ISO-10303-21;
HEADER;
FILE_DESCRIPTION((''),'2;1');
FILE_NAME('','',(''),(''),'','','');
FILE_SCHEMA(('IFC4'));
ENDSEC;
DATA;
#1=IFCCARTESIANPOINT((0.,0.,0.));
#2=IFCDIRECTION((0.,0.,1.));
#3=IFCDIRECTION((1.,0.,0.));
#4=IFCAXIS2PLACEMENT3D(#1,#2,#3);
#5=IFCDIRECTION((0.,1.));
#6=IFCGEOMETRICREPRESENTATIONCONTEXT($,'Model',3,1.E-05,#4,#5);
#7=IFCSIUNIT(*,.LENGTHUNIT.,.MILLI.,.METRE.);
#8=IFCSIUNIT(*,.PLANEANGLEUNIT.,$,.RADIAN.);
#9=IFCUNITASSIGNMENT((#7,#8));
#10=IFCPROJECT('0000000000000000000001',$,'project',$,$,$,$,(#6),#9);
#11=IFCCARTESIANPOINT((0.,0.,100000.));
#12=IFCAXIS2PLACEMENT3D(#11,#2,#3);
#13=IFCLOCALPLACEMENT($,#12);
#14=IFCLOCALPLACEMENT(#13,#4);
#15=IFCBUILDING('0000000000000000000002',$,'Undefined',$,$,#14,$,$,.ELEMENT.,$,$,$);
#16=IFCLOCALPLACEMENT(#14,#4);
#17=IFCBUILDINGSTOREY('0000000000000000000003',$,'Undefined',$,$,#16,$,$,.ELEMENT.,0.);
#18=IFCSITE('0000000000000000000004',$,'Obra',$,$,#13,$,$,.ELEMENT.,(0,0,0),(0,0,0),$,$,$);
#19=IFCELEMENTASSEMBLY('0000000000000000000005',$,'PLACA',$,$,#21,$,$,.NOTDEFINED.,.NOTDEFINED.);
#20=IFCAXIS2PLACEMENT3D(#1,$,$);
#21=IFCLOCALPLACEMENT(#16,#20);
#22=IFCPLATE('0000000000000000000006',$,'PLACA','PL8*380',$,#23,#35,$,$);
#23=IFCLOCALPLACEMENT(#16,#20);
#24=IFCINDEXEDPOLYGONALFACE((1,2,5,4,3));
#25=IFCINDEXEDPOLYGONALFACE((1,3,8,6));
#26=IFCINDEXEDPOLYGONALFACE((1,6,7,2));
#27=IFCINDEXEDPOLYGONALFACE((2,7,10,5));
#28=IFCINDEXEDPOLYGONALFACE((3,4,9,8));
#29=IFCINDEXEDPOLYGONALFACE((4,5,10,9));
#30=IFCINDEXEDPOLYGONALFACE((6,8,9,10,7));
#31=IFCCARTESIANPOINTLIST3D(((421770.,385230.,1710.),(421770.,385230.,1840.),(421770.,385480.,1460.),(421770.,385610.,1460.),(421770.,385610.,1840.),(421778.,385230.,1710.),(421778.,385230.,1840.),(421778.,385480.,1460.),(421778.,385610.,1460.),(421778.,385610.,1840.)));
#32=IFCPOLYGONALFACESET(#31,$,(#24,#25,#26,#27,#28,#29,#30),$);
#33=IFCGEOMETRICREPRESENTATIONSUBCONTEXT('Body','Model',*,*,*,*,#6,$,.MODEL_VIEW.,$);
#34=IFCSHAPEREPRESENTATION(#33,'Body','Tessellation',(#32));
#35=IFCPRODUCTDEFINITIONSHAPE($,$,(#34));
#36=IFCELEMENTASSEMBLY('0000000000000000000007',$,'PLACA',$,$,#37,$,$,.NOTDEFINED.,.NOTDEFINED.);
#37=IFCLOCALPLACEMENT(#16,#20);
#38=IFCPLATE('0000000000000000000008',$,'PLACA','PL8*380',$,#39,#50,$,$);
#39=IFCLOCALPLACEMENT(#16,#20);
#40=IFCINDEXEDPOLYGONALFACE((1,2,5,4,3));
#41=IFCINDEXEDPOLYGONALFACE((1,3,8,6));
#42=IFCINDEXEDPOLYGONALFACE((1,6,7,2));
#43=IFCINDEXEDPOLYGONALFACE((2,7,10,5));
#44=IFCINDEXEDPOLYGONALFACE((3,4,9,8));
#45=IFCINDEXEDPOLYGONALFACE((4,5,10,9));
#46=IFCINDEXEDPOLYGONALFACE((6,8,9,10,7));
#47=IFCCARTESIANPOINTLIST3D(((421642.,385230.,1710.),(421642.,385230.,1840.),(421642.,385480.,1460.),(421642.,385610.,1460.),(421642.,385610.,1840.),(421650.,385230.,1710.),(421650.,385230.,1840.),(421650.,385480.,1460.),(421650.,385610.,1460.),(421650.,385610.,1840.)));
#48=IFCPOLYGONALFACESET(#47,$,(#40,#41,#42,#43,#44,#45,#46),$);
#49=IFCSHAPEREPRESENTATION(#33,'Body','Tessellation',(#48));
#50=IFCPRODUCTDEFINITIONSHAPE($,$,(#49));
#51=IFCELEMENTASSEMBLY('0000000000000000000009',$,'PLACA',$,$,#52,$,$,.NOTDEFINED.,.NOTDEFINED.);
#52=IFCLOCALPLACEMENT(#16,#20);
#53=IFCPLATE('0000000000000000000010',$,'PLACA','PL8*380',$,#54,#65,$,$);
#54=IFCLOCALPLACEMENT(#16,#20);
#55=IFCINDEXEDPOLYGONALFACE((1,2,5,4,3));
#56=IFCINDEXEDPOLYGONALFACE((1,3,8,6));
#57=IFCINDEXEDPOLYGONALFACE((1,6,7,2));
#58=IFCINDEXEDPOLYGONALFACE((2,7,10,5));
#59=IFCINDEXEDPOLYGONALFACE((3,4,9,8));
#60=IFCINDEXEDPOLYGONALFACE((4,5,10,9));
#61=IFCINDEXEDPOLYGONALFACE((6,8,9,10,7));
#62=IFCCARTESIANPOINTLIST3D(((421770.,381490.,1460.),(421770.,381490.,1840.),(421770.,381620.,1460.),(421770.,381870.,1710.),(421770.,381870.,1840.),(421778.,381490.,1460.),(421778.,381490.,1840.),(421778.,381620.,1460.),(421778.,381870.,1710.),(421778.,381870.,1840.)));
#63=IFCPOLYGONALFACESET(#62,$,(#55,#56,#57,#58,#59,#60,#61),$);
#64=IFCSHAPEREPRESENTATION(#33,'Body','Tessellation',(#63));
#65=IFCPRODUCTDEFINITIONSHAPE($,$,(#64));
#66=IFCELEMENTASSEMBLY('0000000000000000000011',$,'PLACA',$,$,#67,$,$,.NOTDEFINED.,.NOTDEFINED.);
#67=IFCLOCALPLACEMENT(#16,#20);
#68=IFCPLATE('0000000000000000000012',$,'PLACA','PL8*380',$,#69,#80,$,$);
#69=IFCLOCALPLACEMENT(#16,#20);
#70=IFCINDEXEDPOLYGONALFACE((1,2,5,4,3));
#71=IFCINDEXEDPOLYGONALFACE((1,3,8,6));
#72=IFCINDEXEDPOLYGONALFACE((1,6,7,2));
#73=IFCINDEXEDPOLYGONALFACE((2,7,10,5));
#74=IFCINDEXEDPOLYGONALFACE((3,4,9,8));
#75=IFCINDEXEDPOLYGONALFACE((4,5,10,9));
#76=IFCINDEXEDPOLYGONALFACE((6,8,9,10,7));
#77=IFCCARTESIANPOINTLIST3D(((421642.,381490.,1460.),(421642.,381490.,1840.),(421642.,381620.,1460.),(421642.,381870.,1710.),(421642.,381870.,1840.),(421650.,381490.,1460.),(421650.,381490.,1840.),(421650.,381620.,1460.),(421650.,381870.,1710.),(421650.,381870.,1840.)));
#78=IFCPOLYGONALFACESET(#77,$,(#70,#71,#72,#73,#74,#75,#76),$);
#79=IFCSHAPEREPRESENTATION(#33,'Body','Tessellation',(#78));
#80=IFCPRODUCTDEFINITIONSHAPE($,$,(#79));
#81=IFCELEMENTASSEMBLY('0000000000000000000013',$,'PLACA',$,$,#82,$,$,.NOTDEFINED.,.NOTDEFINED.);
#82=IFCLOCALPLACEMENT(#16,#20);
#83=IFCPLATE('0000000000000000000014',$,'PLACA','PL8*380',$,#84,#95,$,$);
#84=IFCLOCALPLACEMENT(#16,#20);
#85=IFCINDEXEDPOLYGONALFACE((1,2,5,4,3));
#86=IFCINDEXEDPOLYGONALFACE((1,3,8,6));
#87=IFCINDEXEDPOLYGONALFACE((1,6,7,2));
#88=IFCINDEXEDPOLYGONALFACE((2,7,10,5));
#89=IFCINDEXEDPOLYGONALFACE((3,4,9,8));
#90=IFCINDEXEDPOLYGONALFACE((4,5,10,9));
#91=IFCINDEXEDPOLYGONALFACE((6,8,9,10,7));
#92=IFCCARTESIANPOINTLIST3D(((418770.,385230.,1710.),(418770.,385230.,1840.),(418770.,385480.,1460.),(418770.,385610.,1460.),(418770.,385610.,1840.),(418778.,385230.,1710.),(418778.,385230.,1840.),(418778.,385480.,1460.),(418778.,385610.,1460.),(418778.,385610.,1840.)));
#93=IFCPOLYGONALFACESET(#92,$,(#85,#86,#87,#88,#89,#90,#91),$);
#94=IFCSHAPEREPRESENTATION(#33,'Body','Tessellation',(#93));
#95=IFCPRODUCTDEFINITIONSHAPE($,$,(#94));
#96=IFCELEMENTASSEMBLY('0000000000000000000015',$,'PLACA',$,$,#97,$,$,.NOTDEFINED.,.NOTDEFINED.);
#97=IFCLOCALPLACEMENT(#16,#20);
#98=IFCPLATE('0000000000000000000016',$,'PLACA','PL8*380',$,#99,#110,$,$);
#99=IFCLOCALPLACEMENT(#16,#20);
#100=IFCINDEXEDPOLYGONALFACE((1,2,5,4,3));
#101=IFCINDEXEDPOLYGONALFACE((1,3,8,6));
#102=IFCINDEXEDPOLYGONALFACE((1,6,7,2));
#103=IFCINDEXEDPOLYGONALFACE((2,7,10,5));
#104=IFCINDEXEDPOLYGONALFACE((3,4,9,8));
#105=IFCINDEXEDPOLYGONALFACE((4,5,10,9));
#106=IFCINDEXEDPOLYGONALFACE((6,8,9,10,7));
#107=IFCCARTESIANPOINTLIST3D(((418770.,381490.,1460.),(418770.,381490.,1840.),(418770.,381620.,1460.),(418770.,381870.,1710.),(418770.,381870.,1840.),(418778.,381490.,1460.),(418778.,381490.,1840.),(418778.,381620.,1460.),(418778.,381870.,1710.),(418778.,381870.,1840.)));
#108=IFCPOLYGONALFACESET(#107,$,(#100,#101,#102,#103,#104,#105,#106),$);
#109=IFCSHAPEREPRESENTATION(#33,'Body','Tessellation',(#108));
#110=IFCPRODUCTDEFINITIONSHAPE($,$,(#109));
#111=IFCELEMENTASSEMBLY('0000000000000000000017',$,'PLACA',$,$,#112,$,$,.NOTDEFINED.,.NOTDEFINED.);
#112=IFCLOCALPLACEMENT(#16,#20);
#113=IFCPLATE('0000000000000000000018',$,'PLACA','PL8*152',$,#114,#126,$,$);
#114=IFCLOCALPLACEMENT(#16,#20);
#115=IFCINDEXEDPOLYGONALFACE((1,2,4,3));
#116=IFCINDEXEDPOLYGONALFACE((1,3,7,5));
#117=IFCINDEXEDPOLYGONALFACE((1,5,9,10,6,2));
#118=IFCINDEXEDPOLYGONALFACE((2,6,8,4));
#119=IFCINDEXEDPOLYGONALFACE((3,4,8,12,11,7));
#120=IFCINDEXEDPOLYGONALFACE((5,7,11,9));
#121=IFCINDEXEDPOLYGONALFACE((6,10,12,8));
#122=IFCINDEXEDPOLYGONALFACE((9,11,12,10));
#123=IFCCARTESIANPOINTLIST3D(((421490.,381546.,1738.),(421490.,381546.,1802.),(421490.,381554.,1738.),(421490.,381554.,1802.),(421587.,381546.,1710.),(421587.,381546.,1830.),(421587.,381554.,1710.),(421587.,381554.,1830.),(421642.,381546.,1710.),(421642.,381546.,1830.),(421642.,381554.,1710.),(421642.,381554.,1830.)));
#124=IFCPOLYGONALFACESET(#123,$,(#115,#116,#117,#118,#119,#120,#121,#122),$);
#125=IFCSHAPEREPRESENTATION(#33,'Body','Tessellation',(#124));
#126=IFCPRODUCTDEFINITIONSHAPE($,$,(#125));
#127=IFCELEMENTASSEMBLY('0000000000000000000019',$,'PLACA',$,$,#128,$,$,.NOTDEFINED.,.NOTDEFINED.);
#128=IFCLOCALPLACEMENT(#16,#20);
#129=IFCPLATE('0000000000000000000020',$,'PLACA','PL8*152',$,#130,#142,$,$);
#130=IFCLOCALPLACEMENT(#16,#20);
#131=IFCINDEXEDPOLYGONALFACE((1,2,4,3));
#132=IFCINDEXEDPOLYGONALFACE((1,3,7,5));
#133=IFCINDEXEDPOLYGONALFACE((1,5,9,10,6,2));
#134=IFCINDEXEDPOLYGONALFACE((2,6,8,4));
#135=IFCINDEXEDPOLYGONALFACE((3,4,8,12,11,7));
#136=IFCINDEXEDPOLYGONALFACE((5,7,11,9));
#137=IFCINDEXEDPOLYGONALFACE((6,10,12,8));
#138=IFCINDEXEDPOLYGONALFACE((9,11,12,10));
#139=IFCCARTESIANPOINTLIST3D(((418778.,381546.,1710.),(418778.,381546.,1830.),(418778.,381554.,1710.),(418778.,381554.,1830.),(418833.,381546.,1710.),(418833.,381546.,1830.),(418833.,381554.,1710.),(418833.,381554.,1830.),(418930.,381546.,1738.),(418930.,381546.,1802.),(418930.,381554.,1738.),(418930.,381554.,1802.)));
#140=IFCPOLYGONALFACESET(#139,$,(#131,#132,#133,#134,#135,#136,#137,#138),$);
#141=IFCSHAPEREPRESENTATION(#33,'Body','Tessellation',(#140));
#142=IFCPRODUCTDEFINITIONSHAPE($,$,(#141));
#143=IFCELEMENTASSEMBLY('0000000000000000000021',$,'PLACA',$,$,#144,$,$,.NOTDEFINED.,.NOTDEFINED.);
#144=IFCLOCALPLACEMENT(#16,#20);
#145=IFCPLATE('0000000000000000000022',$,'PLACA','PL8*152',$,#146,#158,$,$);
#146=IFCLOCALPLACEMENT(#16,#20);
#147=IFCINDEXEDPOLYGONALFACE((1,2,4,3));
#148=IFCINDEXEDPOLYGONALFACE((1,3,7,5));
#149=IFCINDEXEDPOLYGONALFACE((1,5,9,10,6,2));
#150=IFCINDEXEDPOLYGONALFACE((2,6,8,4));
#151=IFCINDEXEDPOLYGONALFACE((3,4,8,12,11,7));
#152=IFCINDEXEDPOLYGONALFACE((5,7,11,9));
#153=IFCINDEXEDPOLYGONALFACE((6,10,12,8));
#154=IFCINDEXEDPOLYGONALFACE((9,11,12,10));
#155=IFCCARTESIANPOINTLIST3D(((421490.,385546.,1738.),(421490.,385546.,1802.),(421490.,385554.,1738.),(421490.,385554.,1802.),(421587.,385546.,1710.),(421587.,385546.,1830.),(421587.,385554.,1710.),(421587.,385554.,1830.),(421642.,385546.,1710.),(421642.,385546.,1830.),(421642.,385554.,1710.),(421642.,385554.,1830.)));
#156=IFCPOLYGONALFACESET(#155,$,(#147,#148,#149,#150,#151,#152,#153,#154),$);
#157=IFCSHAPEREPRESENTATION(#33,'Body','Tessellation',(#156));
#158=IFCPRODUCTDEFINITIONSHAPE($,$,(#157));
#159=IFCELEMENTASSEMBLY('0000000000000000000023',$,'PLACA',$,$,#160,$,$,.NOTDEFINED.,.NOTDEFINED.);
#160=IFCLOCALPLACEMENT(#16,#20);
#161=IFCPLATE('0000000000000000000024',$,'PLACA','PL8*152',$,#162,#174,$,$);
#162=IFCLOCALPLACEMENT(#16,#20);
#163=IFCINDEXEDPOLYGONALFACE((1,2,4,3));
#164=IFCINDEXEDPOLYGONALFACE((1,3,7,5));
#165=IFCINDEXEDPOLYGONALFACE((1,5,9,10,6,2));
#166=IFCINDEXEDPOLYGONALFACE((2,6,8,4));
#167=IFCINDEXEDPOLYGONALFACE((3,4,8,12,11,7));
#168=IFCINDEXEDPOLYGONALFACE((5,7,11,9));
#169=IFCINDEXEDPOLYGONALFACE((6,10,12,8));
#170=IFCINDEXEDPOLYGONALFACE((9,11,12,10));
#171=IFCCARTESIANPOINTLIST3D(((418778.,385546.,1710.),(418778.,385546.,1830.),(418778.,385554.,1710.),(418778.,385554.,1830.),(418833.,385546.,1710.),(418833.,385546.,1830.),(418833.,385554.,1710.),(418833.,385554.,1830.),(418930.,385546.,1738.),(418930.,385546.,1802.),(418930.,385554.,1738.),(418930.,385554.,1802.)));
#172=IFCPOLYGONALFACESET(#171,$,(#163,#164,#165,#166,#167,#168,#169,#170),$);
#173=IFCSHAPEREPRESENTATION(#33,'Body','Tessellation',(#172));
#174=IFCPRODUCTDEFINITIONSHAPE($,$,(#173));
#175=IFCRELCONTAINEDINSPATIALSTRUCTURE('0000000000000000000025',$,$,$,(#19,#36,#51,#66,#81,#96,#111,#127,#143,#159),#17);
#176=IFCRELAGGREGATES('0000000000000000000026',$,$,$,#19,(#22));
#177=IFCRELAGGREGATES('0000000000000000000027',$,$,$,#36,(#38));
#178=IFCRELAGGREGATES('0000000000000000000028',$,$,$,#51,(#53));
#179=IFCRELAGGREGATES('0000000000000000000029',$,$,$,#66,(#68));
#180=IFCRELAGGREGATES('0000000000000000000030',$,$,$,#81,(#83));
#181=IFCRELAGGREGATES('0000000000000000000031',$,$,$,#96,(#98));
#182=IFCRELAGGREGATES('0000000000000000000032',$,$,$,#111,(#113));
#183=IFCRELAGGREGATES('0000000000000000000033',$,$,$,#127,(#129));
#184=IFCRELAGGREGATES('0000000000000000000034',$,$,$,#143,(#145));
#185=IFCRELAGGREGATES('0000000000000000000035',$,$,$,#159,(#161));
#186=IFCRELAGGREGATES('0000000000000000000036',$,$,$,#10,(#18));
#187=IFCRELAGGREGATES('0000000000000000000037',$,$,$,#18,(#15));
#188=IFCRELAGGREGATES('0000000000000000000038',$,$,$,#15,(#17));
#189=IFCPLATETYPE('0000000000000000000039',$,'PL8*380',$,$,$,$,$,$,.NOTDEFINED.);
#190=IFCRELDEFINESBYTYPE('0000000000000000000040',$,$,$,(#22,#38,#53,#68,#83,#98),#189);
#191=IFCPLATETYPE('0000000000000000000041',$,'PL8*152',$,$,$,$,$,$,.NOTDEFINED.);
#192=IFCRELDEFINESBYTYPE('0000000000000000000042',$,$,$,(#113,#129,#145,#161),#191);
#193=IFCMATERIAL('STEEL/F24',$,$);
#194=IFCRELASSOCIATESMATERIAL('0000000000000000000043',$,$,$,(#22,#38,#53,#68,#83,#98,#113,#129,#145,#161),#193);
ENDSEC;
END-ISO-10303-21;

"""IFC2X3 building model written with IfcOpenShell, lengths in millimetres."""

from ifc_helpers import new_model, si_unit, direction, frame, origin_with_axes, place, context, subcontext, project, spatial, polyline, outline, extrude, material, type_object, element, aggregate, save


model = new_model("IFC2X3")

# Units and contexts
model_context = context("Model", 3, precision=1e-05, world=origin_with_axes(), true_north=direction((0.0, 1.0)))
body_context = subcontext(model_context, "Body", "Model", "MODEL_VIEW")
ifc_project = project(units=[si_unit("LENGTHUNIT", "METRE", prefix="MILLI"), si_unit("PLANEANGLEUNIT", "RADIAN")], contexts=[model_context])

# Site, building, storey
site_placement = place(None, frame((0.0, 0.0, 100000.0), z_axis=(0.0, 0.0, 1.0), x_axis=(1.0, 0.0, 0.0)))
site = spatial("IfcSite", under=ifc_project, at=site_placement, Name="Obra", CompositionType="ELEMENT", RefLatitude=(0, 0, 0), RefLongitude=(0, 0, 0))
building_placement = place(site_placement, origin_with_axes())
building = spatial("IfcBuilding", under=site, at=building_placement, Name="Undefined", CompositionType="ELEMENT")
storey_placement = place(building_placement, origin_with_axes())
storey = spatial("IfcBuildingStorey", under=building, at=storey_placement, Name="Undefined", CompositionType="ELEMENT", Elevation=0.0)

# Shared definitions
ifc_material_1 = material(Name="STEEL/F24")

# Element assemblies, plates
assembly_1_placement = place(storey_placement, origin_with_axes())
assembly_1 = element("IfcElementAssembly", 1, at=assembly_1_placement, inside=storey, Name="PLACA", AssemblyPlace="NOTDEFINED", PredefinedType="NOTDEFINED")
plate_type_1 = type_object("IfcPlateType", Name="PL8*380", PredefinedType="NOTDEFINED")
plate_1_placement = place(assembly_1_placement, frame((421774.0, 385230.0, 1840.0), z_axis=(-1.0, 0.0, 0.0), x_axis=(0.0, 1.0, 0.0)))
plate_1 = element("IfcPlate", 2, at=plate_1_placement, type_object=plate_type_1, material=ifc_material_1, Name="PLACA", Description="PL8*380", context=body_context, shape_type="SweptSolid", body=[
    extrude(outline(polyline([(0.0, 0.0), (380.0, 0.0), (380.0, 380.0), (250.0, 380.0), (0.0, 130.0), (0.0, 0.0)])), frame((0.0, 0.0, -4.0), z_axis=(0.0, 0.0, 1.0), x_axis=(1.0, 0.0, 0.0)), (0.0, 0.0, 1.0), 8.0),
])
aggregate(assembly_1, [plate_1])
assembly_2_placement = place(storey_placement, origin_with_axes())
assembly_2 = element("IfcElementAssembly", 3, at=assembly_2_placement, inside=storey, Name="PLACA", AssemblyPlace="NOTDEFINED", PredefinedType="NOTDEFINED")
plate_2_placement = place(assembly_2_placement, frame((421646.0, 385230.0, 1840.0), z_axis=(-1.0, 0.0, 0.0), x_axis=(0.0, 1.0, 0.0)))
plate_2 = element("IfcPlate", 4, at=plate_2_placement, type_object=plate_type_1, material=ifc_material_1, Name="PLACA", Description="PL8*380", context=body_context, shape_type="SweptSolid", body=[
    extrude(outline(polyline([(0.0, 0.0), (380.0, 0.0), (380.0, 380.0), (250.0, 380.0), (0.0, 130.0), (0.0, 0.0)])), frame((0.0, 0.0, -4.0), z_axis=(0.0, 0.0, 1.0), x_axis=(1.0, 0.0, 0.0)), (0.0, 0.0, 1.0), 8.0),
])
aggregate(assembly_2, [plate_2])
assembly_3_placement = place(storey_placement, origin_with_axes())
assembly_3 = element("IfcElementAssembly", 5, at=assembly_3_placement, inside=storey, Name="PLACA", AssemblyPlace="NOTDEFINED", PredefinedType="NOTDEFINED")
plate_3_placement = place(assembly_3_placement, frame((421774.0, 381870.0, 1840.0), z_axis=(1.0, 0.0, 0.0), x_axis=(0.0, -1.0, 0.0)))
plate_3 = element("IfcPlate", 6, at=plate_3_placement, type_object=plate_type_1, material=ifc_material_1, Name="PLACA", Description="PL8*380", context=body_context, shape_type="SweptSolid", body=[
    extrude(outline(polyline([(0.0, 0.0), (380.0, 0.0), (380.0, 380.0), (250.0, 380.0), (0.0, 130.0), (0.0, 0.0)])), frame((0.0, 0.0, -4.0), z_axis=(0.0, 0.0, 1.0), x_axis=(1.0, 0.0, 0.0)), (0.0, 0.0, 1.0), 8.0),
])
aggregate(assembly_3, [plate_3])
assembly_4_placement = place(storey_placement, origin_with_axes())
assembly_4 = element("IfcElementAssembly", 7, at=assembly_4_placement, inside=storey, Name="PLACA", AssemblyPlace="NOTDEFINED", PredefinedType="NOTDEFINED")
plate_4_placement = place(assembly_4_placement, frame((421646.0, 381870.0, 1840.0), z_axis=(1.0, 0.0, 0.0), x_axis=(0.0, -1.0, 0.0)))
plate_4 = element("IfcPlate", 8, at=plate_4_placement, type_object=plate_type_1, material=ifc_material_1, Name="PLACA", Description="PL8*380", context=body_context, shape_type="SweptSolid", body=[
    extrude(outline(polyline([(0.0, 0.0), (380.0, 0.0), (380.0, 380.0), (250.0, 380.0), (0.0, 130.0), (0.0, 0.0)])), frame((0.0, 0.0, -4.0), z_axis=(0.0, 0.0, 1.0), x_axis=(1.0, 0.0, 0.0)), (0.0, 0.0, 1.0), 8.0),
])
aggregate(assembly_4, [plate_4])
assembly_5_placement = place(storey_placement, origin_with_axes())
assembly_5 = element("IfcElementAssembly", 9, at=assembly_5_placement, inside=storey, Name="PLACA", AssemblyPlace="NOTDEFINED", PredefinedType="NOTDEFINED")
plate_5_placement = place(assembly_5_placement, frame((418774.0, 385230.0, 1840.0), z_axis=(-1.0, 0.0, 0.0), x_axis=(0.0, 1.0, 0.0)))
plate_5 = element("IfcPlate", 10, at=plate_5_placement, type_object=plate_type_1, material=ifc_material_1, Name="PLACA", Description="PL8*380", context=body_context, shape_type="SweptSolid", body=[
    extrude(outline(polyline([(0.0, 0.0), (380.0, 0.0), (380.0, 380.0), (250.0, 380.0), (0.0, 130.0), (0.0, 0.0)])), frame((0.0, 0.0, -4.0), z_axis=(0.0, 0.0, 1.0), x_axis=(1.0, 0.0, 0.0)), (0.0, 0.0, 1.0), 8.0),
])
aggregate(assembly_5, [plate_5])
assembly_6_placement = place(storey_placement, origin_with_axes())
assembly_6 = element("IfcElementAssembly", 11, at=assembly_6_placement, inside=storey, Name="PLACA", AssemblyPlace="NOTDEFINED", PredefinedType="NOTDEFINED")
plate_6_placement = place(assembly_6_placement, frame((418774.0, 381870.0, 1840.0), z_axis=(1.0, 0.0, 0.0), x_axis=(0.0, -1.0, 0.0)))
plate_6 = element("IfcPlate", 12, at=plate_6_placement, type_object=plate_type_1, material=ifc_material_1, Name="PLACA", Description="PL8*380", context=body_context, shape_type="SweptSolid", body=[
    extrude(outline(polyline([(0.0, 0.0), (380.0, 0.0), (380.0, 380.0), (250.0, 380.0), (0.0, 130.0), (0.0, 0.0)])), frame((0.0, 0.0, -4.0), z_axis=(0.0, 0.0, 1.0), x_axis=(1.0, 0.0, 0.0)), (0.0, 0.0, 1.0), 8.0),
])
aggregate(assembly_6, [plate_6])
assembly_7_placement = place(storey_placement, origin_with_axes())
assembly_7 = element("IfcElementAssembly", 13, at=assembly_7_placement, inside=storey, Name="PLACA", AssemblyPlace="NOTDEFINED", PredefinedType="NOTDEFINED")
plate_type_2 = type_object("IfcPlateType", Name="PL8*152", PredefinedType="NOTDEFINED")
plate_7_placement = place(assembly_7_placement, frame((421587.0, 381550.0, 1830.0), z_axis=(0.0, 1.0, 0.0), x_axis=(1.0, 0.0, 0.0)))
plate_7 = element("IfcPlate", 14, at=plate_7_placement, type_object=plate_type_2, material=ifc_material_1, Name="PLACA", Description="PL8*152", context=body_context, shape_type="SweptSolid", body=[
    extrude(outline(polyline([(0.0, 0.0), (55.0, 0.0), (55.0, 120.0), (0.0, 120.0), (-97.0, 92.0), (-97.0, 28.0), (0.0, 0.0)])), frame((0.0, 0.0, -4.0), z_axis=(0.0, 0.0, 1.0), x_axis=(1.0, 0.0, 0.0)), (0.0, 0.0, 1.0), 8.0),
])
aggregate(assembly_7, [plate_7])
assembly_8_placement = place(storey_placement, origin_with_axes())
assembly_8 = element("IfcElementAssembly", 15, at=assembly_8_placement, inside=storey, Name="PLACA", AssemblyPlace="NOTDEFINED", PredefinedType="NOTDEFINED")
plate_8_placement = place(assembly_8_placement, frame((418833.0, 381550.0, 1830.0), z_axis=(0.0, -1.0, 0.0), x_axis=(-1.0, 0.0, 0.0)))
plate_8 = element("IfcPlate", 16, at=plate_8_placement, type_object=plate_type_2, material=ifc_material_1, Name="PLACA", Description="PL8*152", context=body_context, shape_type="SweptSolid", body=[
    extrude(outline(polyline([(0.0, 0.0), (55.0, 0.0), (55.0, 120.0), (0.0, 120.0), (-97.0, 92.0), (-97.0, 28.0), (0.0, 0.0)])), frame((0.0, 0.0, -4.0), z_axis=(0.0, 0.0, 1.0), x_axis=(1.0, 0.0, 0.0)), (0.0, 0.0, 1.0), 8.0),
])
aggregate(assembly_8, [plate_8])
assembly_9_placement = place(storey_placement, origin_with_axes())
assembly_9 = element("IfcElementAssembly", 17, at=assembly_9_placement, inside=storey, Name="PLACA", AssemblyPlace="NOTDEFINED", PredefinedType="NOTDEFINED")
plate_9_placement = place(assembly_9_placement, frame((421587.0, 385550.0, 1830.0), z_axis=(0.0, 1.0, 0.0), x_axis=(1.0, 0.0, 0.0)))
plate_9 = element("IfcPlate", 18, at=plate_9_placement, type_object=plate_type_2, material=ifc_material_1, Name="PLACA", Description="PL8*152", context=body_context, shape_type="SweptSolid", body=[
    extrude(outline(polyline([(0.0, 0.0), (55.0, 0.0), (55.0, 120.0), (0.0, 120.0), (-97.0, 92.0), (-97.0, 28.0), (0.0, 0.0)])), frame((0.0, 0.0, -4.0), z_axis=(0.0, 0.0, 1.0), x_axis=(1.0, 0.0, 0.0)), (0.0, 0.0, 1.0), 8.0),
])
aggregate(assembly_9, [plate_9])
assembly_10_placement = place(storey_placement, origin_with_axes())
assembly_10 = element("IfcElementAssembly", 19, at=assembly_10_placement, inside=storey, Name="PLACA", AssemblyPlace="NOTDEFINED", PredefinedType="NOTDEFINED")
plate_10_placement = place(assembly_10_placement, frame((418833.0, 385550.0, 1830.0), z_axis=(0.0, -1.0, 0.0), x_axis=(-1.0, 0.0, 0.0)))
plate_10 = element("IfcPlate", 20, at=plate_10_placement, type_object=plate_type_2, material=ifc_material_1, Name="PLACA", Description="PL8*152", context=body_context, shape_type="SweptSolid", body=[
    extrude(outline(polyline([(0.0, 0.0), (55.0, 0.0), (55.0, 120.0), (0.0, 120.0), (-97.0, 92.0), (-97.0, 28.0), (0.0, 0.0)])), frame((0.0, 0.0, -4.0), z_axis=(0.0, 0.0, 1.0), x_axis=(1.0, 0.0, 0.0)), (0.0, 0.0, 1.0), 8.0),
])
aggregate(assembly_10, [plate_10])

save(model, "model.ifc")
